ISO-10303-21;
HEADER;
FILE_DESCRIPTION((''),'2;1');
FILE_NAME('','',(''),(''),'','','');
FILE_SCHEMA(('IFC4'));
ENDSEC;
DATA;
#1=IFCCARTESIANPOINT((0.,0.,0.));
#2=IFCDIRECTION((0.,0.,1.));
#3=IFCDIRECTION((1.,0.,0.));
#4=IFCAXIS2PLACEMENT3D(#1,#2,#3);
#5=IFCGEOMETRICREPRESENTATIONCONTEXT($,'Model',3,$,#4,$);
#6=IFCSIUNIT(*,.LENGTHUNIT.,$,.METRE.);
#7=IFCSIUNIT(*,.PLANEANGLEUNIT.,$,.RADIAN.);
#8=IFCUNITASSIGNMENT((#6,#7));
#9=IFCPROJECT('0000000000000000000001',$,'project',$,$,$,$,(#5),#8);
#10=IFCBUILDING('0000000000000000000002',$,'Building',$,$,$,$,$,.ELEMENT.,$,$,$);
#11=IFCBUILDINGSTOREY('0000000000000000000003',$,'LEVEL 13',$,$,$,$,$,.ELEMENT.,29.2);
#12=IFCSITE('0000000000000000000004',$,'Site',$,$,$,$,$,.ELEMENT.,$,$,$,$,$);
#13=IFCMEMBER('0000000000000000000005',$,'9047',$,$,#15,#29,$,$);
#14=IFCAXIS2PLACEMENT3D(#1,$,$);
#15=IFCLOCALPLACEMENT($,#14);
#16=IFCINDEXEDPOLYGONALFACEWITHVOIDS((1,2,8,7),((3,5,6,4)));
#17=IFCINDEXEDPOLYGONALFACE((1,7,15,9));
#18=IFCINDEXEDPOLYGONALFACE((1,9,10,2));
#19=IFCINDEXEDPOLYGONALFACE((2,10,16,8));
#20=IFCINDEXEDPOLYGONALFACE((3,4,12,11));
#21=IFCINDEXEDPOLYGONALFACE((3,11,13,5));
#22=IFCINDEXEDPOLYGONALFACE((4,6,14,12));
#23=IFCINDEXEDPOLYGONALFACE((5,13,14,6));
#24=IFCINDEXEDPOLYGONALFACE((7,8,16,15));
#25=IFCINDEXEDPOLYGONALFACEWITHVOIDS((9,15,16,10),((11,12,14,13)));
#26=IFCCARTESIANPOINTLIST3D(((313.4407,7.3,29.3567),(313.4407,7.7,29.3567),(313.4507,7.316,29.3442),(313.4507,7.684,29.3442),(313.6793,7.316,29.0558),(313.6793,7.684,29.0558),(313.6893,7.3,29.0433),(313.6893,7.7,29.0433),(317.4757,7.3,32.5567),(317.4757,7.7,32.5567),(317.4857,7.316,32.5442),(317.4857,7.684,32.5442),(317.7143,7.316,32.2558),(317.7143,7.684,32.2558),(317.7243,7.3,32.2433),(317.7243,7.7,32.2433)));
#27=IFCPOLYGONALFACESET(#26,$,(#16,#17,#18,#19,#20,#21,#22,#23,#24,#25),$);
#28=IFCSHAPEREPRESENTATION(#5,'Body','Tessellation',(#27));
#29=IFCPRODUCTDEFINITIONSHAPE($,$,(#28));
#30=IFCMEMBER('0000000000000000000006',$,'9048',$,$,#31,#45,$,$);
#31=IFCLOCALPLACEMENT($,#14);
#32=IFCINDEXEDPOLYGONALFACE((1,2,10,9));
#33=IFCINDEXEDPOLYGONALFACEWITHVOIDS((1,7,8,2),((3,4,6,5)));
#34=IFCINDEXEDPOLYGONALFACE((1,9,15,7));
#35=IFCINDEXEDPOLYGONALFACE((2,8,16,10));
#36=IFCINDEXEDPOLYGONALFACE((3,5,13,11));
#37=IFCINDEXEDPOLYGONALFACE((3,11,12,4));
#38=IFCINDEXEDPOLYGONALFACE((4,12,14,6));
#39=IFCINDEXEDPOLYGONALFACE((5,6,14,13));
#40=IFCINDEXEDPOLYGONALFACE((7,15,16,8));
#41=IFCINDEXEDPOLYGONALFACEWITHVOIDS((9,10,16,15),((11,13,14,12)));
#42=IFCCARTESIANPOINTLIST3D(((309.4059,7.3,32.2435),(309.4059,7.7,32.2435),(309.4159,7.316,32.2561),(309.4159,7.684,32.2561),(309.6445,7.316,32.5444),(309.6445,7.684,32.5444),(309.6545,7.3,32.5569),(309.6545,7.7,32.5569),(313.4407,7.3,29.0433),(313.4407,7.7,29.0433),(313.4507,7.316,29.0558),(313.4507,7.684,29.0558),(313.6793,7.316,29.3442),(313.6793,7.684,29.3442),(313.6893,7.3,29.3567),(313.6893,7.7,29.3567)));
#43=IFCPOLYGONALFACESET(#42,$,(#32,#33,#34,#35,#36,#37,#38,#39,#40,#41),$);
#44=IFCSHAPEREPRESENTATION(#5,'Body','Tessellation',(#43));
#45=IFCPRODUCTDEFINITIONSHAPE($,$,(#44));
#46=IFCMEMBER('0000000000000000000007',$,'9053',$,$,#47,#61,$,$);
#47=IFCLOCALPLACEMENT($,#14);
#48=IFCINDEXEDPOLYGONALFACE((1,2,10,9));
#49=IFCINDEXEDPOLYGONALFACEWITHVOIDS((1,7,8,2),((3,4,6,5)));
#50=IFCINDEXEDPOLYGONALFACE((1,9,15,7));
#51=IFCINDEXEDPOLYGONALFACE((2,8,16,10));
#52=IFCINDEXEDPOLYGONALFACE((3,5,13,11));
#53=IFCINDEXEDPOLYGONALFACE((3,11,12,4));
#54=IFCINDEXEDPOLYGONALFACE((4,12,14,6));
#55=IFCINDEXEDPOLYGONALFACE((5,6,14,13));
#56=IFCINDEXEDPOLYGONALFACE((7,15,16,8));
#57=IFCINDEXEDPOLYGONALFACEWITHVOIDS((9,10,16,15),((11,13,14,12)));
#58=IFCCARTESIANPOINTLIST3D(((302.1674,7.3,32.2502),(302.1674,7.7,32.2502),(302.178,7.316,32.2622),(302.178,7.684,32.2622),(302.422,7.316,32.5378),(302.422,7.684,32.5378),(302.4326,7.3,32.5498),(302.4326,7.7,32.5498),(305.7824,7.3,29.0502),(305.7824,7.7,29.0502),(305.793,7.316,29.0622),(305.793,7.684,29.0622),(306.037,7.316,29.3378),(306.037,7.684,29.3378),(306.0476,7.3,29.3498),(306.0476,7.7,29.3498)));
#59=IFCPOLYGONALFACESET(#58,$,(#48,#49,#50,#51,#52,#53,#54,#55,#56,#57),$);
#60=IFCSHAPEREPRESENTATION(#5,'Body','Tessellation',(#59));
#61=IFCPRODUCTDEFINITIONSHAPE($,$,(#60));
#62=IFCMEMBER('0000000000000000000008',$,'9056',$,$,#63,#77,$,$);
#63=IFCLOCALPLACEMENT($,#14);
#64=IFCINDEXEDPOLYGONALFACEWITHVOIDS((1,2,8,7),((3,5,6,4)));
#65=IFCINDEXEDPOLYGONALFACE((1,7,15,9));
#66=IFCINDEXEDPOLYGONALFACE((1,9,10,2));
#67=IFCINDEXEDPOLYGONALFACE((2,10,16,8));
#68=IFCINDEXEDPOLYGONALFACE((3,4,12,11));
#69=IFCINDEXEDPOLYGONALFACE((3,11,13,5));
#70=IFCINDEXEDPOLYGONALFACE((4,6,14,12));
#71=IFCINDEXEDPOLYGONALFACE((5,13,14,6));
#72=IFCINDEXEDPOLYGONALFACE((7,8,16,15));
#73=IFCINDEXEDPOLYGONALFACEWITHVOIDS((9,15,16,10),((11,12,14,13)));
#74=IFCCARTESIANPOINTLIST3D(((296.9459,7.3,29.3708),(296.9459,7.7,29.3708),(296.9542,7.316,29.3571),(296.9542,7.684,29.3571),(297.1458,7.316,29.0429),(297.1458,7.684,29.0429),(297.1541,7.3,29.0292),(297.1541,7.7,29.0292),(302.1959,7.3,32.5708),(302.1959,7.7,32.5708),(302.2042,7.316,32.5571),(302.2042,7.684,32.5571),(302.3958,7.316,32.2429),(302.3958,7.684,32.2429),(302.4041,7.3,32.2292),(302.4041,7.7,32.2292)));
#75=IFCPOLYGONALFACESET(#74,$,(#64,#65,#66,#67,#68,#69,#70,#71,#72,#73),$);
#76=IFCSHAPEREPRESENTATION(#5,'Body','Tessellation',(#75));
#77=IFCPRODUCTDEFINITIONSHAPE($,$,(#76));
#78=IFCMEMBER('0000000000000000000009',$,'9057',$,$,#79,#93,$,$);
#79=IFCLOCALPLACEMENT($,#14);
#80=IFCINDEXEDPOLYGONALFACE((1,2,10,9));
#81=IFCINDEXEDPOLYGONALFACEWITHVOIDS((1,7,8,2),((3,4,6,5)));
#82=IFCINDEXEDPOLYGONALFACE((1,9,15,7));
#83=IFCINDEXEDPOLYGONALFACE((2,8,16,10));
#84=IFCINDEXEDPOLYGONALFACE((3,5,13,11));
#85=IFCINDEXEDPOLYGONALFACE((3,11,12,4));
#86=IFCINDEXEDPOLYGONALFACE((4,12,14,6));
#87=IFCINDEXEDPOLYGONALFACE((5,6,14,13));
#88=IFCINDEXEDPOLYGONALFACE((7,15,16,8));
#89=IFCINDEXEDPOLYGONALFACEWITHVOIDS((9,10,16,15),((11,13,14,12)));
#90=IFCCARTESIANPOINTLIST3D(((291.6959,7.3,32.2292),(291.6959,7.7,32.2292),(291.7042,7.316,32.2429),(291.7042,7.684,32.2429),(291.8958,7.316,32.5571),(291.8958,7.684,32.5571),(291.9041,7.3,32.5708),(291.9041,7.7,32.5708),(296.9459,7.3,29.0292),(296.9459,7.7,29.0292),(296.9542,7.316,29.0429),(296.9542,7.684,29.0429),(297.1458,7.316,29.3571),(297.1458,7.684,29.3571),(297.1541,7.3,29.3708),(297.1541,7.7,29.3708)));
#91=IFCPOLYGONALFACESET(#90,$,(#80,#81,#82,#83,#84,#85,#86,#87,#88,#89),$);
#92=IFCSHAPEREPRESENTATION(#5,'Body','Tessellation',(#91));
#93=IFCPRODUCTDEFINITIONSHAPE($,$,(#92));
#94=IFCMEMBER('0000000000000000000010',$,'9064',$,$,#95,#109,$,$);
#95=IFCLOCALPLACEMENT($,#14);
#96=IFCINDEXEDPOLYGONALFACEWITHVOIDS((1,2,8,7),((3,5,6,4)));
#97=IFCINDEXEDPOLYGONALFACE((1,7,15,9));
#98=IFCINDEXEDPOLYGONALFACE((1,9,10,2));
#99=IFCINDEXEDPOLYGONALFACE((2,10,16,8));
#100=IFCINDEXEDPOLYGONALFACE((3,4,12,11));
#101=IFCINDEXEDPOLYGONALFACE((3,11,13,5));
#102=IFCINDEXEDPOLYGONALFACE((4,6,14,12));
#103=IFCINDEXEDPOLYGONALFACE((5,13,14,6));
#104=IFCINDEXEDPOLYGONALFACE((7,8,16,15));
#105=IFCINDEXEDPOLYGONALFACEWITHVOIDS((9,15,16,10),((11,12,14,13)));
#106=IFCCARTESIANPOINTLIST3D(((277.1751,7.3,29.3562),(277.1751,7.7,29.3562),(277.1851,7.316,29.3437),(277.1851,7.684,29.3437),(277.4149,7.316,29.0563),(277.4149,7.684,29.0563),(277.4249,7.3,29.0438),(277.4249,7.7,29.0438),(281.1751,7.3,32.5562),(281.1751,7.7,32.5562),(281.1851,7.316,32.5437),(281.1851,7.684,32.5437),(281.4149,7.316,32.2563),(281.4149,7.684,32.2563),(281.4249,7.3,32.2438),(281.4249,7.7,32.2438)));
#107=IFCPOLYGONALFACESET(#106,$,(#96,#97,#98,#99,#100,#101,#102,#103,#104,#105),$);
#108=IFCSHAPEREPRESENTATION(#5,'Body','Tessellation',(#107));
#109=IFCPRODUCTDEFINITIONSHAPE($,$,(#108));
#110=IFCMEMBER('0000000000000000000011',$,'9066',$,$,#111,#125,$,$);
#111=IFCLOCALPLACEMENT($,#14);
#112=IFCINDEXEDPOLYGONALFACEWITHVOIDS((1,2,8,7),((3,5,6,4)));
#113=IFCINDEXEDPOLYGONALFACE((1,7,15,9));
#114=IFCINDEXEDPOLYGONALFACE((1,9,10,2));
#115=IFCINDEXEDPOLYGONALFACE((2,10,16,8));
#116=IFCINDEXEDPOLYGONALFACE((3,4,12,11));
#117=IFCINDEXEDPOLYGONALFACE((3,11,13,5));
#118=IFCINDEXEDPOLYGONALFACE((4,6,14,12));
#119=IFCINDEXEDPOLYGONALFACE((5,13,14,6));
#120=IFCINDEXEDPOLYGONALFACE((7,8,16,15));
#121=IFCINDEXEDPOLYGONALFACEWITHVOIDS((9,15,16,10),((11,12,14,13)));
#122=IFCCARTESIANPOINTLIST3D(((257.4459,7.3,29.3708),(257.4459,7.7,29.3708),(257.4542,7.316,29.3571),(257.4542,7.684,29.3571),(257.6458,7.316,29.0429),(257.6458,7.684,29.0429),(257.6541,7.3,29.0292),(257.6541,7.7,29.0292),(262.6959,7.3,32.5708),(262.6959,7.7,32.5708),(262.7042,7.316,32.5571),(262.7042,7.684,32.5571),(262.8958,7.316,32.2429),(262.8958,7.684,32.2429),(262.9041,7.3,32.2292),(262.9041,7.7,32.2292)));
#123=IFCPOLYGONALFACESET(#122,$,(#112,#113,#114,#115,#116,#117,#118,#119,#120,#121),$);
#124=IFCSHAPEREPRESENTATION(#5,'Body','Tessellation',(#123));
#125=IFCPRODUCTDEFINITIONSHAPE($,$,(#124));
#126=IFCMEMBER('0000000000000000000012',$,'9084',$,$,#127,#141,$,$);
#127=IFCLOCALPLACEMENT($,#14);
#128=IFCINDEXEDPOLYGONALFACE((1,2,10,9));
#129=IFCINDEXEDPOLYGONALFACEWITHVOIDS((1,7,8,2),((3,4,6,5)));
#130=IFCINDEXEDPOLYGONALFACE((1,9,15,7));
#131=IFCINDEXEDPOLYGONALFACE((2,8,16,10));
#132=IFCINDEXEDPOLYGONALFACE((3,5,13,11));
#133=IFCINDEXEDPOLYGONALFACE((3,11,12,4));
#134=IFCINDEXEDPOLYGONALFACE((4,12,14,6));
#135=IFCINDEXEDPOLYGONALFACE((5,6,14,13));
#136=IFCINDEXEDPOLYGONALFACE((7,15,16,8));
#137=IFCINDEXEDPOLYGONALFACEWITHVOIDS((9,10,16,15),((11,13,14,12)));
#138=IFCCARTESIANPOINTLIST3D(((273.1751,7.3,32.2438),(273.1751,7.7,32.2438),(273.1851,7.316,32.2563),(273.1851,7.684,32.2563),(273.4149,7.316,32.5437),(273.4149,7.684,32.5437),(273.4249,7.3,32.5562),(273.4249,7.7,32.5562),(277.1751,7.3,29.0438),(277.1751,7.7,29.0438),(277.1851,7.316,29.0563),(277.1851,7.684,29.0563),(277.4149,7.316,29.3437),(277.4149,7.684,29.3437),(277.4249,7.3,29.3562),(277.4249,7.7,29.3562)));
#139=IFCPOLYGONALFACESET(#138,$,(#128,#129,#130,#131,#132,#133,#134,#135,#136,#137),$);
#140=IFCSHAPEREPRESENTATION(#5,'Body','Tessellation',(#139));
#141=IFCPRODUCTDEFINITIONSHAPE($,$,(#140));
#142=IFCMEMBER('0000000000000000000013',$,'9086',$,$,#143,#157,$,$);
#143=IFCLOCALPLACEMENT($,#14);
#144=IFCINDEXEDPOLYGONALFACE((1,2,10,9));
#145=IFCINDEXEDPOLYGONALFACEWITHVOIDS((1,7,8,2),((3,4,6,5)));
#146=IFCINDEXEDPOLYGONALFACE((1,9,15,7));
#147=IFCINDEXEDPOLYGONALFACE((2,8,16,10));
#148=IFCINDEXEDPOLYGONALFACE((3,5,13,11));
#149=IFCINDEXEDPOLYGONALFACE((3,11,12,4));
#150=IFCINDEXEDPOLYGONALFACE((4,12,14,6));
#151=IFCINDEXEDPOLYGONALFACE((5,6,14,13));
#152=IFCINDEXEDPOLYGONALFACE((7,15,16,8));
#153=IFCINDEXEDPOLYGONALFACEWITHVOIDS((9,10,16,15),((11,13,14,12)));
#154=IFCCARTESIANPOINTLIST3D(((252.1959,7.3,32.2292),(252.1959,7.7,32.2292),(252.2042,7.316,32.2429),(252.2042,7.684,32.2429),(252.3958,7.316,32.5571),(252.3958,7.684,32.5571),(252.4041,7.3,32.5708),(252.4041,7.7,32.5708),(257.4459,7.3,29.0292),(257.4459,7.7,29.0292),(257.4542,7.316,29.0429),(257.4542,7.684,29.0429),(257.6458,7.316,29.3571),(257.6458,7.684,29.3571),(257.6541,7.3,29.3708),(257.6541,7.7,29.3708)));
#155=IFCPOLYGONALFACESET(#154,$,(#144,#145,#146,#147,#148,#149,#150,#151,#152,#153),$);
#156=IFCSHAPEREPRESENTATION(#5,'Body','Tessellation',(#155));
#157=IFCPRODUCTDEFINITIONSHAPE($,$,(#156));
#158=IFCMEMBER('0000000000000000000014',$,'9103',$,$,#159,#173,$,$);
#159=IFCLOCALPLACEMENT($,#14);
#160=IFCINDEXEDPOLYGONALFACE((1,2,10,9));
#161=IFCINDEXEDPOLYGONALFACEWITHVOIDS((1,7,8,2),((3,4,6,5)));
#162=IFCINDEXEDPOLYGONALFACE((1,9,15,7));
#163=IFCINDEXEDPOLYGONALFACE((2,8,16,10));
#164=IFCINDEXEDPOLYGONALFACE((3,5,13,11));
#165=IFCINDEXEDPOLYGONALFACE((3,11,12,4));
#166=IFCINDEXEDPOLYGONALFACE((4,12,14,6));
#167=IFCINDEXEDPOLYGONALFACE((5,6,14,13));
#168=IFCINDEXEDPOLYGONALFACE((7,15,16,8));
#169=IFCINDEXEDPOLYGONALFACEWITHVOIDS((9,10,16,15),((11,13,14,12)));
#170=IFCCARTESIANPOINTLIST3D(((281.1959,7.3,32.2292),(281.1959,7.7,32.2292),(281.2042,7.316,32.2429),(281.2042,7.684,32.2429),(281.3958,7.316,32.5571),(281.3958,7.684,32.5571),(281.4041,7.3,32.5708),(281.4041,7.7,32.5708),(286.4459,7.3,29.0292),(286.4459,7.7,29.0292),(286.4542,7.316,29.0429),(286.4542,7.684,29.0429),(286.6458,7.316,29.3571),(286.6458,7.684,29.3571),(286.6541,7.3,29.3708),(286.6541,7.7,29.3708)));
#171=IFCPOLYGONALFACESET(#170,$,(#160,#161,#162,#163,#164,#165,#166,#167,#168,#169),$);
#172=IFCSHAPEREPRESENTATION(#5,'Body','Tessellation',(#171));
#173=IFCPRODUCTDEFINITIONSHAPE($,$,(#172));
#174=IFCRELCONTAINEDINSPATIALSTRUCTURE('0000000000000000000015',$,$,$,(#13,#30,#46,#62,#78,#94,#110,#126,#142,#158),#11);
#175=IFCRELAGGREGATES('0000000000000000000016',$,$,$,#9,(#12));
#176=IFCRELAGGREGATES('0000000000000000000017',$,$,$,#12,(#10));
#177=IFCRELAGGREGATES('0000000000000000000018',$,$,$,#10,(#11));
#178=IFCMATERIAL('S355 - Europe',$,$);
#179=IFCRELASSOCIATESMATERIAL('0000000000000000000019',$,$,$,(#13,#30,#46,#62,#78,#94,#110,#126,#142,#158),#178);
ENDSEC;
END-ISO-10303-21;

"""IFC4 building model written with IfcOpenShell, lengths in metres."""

from ifc_helpers import new_model, si_unit, frame, origin_with_axes, origin_2d_with_axis, place, context, project, spatial, hollow_rectangle, extrude, material, material_profile, profile_set, profile_usage, element, save


model = new_model("IFC4")

# Units and contexts
model_context = context("Model", 3, world=origin_with_axes())
ifc_project = project(units=[si_unit("LENGTHUNIT", "METRE"), si_unit("PLANEANGLEUNIT", "RADIAN")], contexts=[model_context])

# Site, building, storey
site = spatial("IfcSite", under=ifc_project, Name="Site", CompositionType="ELEMENT")
building = spatial("IfcBuilding", under=site, Name="Building", CompositionType="ELEMENT")
storey = spatial("IfcBuildingStorey", under=building, Name="LEVEL 13", CompositionType="ELEMENT", Elevation=29.2)

# Members
ifc_material = material(Name="S355 - Europe")
ifc_material_profile_1 = material_profile(ifc_material, hollow_rectangle(XDim=0.4, YDim=0.4, WallThickness=0.016, at=origin_2d_with_axis()))
ifc_profile_set_1 = profile_set([ifc_material_profile_1])
ifc_profile_usage_1 = profile_usage(ifc_profile_set_1, cardinal=10)
member_1_placement = place(None, frame((317.6, 7.5, 32.4), z_axis=(-0.783514, 0.0, -0.621374), x_axis=(0.0, -1.0, 0.0)))
element("IfcMember", 1, at=member_1_placement, inside=storey, material=ifc_profile_usage_1, Name="9047", context=model_context, shape_type="SweptSolid", body=[
    extrude(hollow_rectangle(XDim=0.4, YDim=0.4, WallThickness=0.016, at=origin_2d_with_axis()), origin_with_axes(), (0.0, 0.0, 1.0), 5.1499),
])
ifc_material_profile_2 = material_profile(ifc_material, hollow_rectangle(XDim=0.4, YDim=0.4, WallThickness=0.016, at=origin_2d_with_axis()))
ifc_profile_set_2 = profile_set([ifc_material_profile_2])
ifc_profile_usage_2 = profile_usage(ifc_profile_set_2, cardinal=10)
member_2_placement = place(None, frame((313.565, 7.5, 29.2), z_axis=(-0.783476, 0.0, 0.621421), x_axis=(0.0, -1.0, 0.0)))
element("IfcMember", 2, at=member_2_placement, inside=storey, material=ifc_profile_usage_2, Name="9048", context=model_context, shape_type="SweptSolid", body=[
    extrude(hollow_rectangle(XDim=0.4, YDim=0.4, WallThickness=0.016, at=origin_2d_with_axis()), origin_with_axes(), (0.0, 0.0, 1.0), 5.1499),
])
ifc_material_profile_3 = material_profile(ifc_material, hollow_rectangle(XDim=0.4, YDim=0.4, WallThickness=0.016, at=origin_2d_with_axis()))
ifc_profile_set_3 = profile_set([ifc_material_profile_3])
ifc_profile_usage_3 = profile_usage(ifc_profile_set_3, cardinal=10)
member_3_placement = place(None, frame((305.915, 7.5, 29.2), z_axis=(-0.748779, 0.0, 0.66282), x_axis=(0.0, -1.0, 0.0)))
element("IfcMember", 3, at=member_3_placement, inside=storey, material=ifc_profile_usage_3, Name="9053", context=model_context, shape_type="SweptSolid", body=[
    extrude(hollow_rectangle(XDim=0.4, YDim=0.4, WallThickness=0.016, at=origin_2d_with_axis()), origin_with_axes(), (0.0, 0.0, 1.0), 4.8279),
])
ifc_material_profile_4 = material_profile(ifc_material, hollow_rectangle(XDim=0.4, YDim=0.4, WallThickness=0.016, at=origin_2d_with_axis()))
ifc_profile_set_4 = profile_set([ifc_material_profile_4])
ifc_profile_usage_4 = profile_usage(ifc_profile_set_4, cardinal=10)
member_4_placement = place(None, frame((302.3, 7.5, 32.4), z_axis=(-0.853884, 0.0, -0.520463), x_axis=(0.0, -1.0, 0.0)))
element("IfcMember", 4, at=member_4_placement, inside=storey, material=ifc_profile_usage_4, Name="9056", context=model_context, shape_type="SweptSolid", body=[
    extrude(hollow_rectangle(XDim=0.4, YDim=0.4, WallThickness=0.016, at=origin_2d_with_axis()), origin_with_axes(), (0.0, 0.0, 1.0), 6.1484),
])
ifc_material_profile_5 = material_profile(ifc_material, hollow_rectangle(XDim=0.4, YDim=0.4, WallThickness=0.016, at=origin_2d_with_axis()))
ifc_profile_set_5 = profile_set([ifc_material_profile_5])
ifc_profile_usage_5 = profile_usage(ifc_profile_set_5, cardinal=10)
member_5_placement = place(None, frame((297.05, 7.5, 29.2), z_axis=(-0.853884, 0.0, 0.520463), x_axis=(0.0, -1.0, 0.0)))
element("IfcMember", 5, at=member_5_placement, inside=storey, material=ifc_profile_usage_5, Name="9057", context=model_context, shape_type="SweptSolid", body=[
    extrude(hollow_rectangle(XDim=0.4, YDim=0.4, WallThickness=0.016, at=origin_2d_with_axis()), origin_with_axes(), (0.0, 0.0, 1.0), 6.1484),
])
ifc_material_profile_6 = material_profile(ifc_material, hollow_rectangle(XDim=0.4, YDim=0.4, WallThickness=0.016, at=origin_2d_with_axis()))
ifc_profile_set_6 = profile_set([ifc_material_profile_6])
ifc_profile_usage_6 = profile_usage(ifc_profile_set_6, cardinal=10)
member_6_placement = place(None, frame((281.3, 7.5, 32.4), z_axis=(-0.780869, 0.0, -0.624695), x_axis=(0.0, -1.0, 0.0)))
element("IfcMember", 6, at=member_6_placement, inside=storey, material=ifc_profile_usage_6, Name="9064", context=model_context, shape_type="SweptSolid", body=[
    extrude(hollow_rectangle(XDim=0.4, YDim=0.4, WallThickness=0.016, at=origin_2d_with_axis()), origin_with_axes(), (0.0, 0.0, 1.0), 5.1225),
])
ifc_material_profile_7 = material_profile(ifc_material, hollow_rectangle(XDim=0.4, YDim=0.4, WallThickness=0.016, at=origin_2d_with_axis()))
ifc_profile_set_7 = profile_set([ifc_material_profile_7])
ifc_profile_usage_7 = profile_usage(ifc_profile_set_7, cardinal=10)
member_7_placement = place(None, frame((262.8, 7.5, 32.4), z_axis=(-0.853884, 0.0, -0.520463), x_axis=(0.0, -1.0, 0.0)))
element("IfcMember", 7, at=member_7_placement, inside=storey, material=ifc_profile_usage_7, Name="9066", context=model_context, shape_type="SweptSolid", body=[
    extrude(hollow_rectangle(XDim=0.4, YDim=0.4, WallThickness=0.016, at=origin_2d_with_axis()), origin_with_axes(), (0.0, 0.0, 1.0), 6.1484),
])
ifc_material_profile_8 = material_profile(ifc_material, hollow_rectangle(XDim=0.4, YDim=0.4, WallThickness=0.016, at=origin_2d_with_axis()))
ifc_profile_set_8 = profile_set([ifc_material_profile_8])
ifc_profile_usage_8 = profile_usage(ifc_profile_set_8, cardinal=10)
member_8_placement = place(None, frame((277.3, 7.5, 29.2), z_axis=(-0.780869, 0.0, 0.624695), x_axis=(0.0, -1.0, 0.0)))
element("IfcMember", 8, at=member_8_placement, inside=storey, material=ifc_profile_usage_8, Name="9084", context=model_context, shape_type="SweptSolid", body=[
    extrude(hollow_rectangle(XDim=0.4, YDim=0.4, WallThickness=0.016, at=origin_2d_with_axis()), origin_with_axes(), (0.0, 0.0, 1.0), 5.1225),
])
ifc_material_profile_9 = material_profile(ifc_material, hollow_rectangle(XDim=0.4, YDim=0.4, WallThickness=0.016, at=origin_2d_with_axis()))
ifc_profile_set_9 = profile_set([ifc_material_profile_9])
ifc_profile_usage_9 = profile_usage(ifc_profile_set_9, cardinal=10)
member_9_placement = place(None, frame((257.55, 7.5, 29.2), z_axis=(-0.853884, 0.0, 0.520463), x_axis=(0.0, -1.0, 0.0)))
element("IfcMember", 9, at=member_9_placement, inside=storey, material=ifc_profile_usage_9, Name="9086", context=model_context, shape_type="SweptSolid", body=[
    extrude(hollow_rectangle(XDim=0.4, YDim=0.4, WallThickness=0.016, at=origin_2d_with_axis()), origin_with_axes(), (0.0, 0.0, 1.0), 6.1484),
])
ifc_material_profile_10 = material_profile(ifc_material, hollow_rectangle(XDim=0.4, YDim=0.4, WallThickness=0.016, at=origin_2d_with_axis()))
ifc_profile_set_10 = profile_set([ifc_material_profile_10])
ifc_profile_usage_10 = profile_usage(ifc_profile_set_10, cardinal=10)
member_10_placement = place(None, frame((286.55, 7.5, 29.2), z_axis=(-0.853884, 0.0, 0.520463), x_axis=(0.0, -1.0, 0.0)))
element("IfcMember", 10, at=member_10_placement, inside=storey, material=ifc_profile_usage_10, Name="9103", context=model_context, shape_type="SweptSolid", body=[
    extrude(hollow_rectangle(XDim=0.4, YDim=0.4, WallThickness=0.016, at=origin_2d_with_axis()), origin_with_axes(), (0.0, 0.0, 1.0), 6.1484),
])

save(model, "model.ifc")
